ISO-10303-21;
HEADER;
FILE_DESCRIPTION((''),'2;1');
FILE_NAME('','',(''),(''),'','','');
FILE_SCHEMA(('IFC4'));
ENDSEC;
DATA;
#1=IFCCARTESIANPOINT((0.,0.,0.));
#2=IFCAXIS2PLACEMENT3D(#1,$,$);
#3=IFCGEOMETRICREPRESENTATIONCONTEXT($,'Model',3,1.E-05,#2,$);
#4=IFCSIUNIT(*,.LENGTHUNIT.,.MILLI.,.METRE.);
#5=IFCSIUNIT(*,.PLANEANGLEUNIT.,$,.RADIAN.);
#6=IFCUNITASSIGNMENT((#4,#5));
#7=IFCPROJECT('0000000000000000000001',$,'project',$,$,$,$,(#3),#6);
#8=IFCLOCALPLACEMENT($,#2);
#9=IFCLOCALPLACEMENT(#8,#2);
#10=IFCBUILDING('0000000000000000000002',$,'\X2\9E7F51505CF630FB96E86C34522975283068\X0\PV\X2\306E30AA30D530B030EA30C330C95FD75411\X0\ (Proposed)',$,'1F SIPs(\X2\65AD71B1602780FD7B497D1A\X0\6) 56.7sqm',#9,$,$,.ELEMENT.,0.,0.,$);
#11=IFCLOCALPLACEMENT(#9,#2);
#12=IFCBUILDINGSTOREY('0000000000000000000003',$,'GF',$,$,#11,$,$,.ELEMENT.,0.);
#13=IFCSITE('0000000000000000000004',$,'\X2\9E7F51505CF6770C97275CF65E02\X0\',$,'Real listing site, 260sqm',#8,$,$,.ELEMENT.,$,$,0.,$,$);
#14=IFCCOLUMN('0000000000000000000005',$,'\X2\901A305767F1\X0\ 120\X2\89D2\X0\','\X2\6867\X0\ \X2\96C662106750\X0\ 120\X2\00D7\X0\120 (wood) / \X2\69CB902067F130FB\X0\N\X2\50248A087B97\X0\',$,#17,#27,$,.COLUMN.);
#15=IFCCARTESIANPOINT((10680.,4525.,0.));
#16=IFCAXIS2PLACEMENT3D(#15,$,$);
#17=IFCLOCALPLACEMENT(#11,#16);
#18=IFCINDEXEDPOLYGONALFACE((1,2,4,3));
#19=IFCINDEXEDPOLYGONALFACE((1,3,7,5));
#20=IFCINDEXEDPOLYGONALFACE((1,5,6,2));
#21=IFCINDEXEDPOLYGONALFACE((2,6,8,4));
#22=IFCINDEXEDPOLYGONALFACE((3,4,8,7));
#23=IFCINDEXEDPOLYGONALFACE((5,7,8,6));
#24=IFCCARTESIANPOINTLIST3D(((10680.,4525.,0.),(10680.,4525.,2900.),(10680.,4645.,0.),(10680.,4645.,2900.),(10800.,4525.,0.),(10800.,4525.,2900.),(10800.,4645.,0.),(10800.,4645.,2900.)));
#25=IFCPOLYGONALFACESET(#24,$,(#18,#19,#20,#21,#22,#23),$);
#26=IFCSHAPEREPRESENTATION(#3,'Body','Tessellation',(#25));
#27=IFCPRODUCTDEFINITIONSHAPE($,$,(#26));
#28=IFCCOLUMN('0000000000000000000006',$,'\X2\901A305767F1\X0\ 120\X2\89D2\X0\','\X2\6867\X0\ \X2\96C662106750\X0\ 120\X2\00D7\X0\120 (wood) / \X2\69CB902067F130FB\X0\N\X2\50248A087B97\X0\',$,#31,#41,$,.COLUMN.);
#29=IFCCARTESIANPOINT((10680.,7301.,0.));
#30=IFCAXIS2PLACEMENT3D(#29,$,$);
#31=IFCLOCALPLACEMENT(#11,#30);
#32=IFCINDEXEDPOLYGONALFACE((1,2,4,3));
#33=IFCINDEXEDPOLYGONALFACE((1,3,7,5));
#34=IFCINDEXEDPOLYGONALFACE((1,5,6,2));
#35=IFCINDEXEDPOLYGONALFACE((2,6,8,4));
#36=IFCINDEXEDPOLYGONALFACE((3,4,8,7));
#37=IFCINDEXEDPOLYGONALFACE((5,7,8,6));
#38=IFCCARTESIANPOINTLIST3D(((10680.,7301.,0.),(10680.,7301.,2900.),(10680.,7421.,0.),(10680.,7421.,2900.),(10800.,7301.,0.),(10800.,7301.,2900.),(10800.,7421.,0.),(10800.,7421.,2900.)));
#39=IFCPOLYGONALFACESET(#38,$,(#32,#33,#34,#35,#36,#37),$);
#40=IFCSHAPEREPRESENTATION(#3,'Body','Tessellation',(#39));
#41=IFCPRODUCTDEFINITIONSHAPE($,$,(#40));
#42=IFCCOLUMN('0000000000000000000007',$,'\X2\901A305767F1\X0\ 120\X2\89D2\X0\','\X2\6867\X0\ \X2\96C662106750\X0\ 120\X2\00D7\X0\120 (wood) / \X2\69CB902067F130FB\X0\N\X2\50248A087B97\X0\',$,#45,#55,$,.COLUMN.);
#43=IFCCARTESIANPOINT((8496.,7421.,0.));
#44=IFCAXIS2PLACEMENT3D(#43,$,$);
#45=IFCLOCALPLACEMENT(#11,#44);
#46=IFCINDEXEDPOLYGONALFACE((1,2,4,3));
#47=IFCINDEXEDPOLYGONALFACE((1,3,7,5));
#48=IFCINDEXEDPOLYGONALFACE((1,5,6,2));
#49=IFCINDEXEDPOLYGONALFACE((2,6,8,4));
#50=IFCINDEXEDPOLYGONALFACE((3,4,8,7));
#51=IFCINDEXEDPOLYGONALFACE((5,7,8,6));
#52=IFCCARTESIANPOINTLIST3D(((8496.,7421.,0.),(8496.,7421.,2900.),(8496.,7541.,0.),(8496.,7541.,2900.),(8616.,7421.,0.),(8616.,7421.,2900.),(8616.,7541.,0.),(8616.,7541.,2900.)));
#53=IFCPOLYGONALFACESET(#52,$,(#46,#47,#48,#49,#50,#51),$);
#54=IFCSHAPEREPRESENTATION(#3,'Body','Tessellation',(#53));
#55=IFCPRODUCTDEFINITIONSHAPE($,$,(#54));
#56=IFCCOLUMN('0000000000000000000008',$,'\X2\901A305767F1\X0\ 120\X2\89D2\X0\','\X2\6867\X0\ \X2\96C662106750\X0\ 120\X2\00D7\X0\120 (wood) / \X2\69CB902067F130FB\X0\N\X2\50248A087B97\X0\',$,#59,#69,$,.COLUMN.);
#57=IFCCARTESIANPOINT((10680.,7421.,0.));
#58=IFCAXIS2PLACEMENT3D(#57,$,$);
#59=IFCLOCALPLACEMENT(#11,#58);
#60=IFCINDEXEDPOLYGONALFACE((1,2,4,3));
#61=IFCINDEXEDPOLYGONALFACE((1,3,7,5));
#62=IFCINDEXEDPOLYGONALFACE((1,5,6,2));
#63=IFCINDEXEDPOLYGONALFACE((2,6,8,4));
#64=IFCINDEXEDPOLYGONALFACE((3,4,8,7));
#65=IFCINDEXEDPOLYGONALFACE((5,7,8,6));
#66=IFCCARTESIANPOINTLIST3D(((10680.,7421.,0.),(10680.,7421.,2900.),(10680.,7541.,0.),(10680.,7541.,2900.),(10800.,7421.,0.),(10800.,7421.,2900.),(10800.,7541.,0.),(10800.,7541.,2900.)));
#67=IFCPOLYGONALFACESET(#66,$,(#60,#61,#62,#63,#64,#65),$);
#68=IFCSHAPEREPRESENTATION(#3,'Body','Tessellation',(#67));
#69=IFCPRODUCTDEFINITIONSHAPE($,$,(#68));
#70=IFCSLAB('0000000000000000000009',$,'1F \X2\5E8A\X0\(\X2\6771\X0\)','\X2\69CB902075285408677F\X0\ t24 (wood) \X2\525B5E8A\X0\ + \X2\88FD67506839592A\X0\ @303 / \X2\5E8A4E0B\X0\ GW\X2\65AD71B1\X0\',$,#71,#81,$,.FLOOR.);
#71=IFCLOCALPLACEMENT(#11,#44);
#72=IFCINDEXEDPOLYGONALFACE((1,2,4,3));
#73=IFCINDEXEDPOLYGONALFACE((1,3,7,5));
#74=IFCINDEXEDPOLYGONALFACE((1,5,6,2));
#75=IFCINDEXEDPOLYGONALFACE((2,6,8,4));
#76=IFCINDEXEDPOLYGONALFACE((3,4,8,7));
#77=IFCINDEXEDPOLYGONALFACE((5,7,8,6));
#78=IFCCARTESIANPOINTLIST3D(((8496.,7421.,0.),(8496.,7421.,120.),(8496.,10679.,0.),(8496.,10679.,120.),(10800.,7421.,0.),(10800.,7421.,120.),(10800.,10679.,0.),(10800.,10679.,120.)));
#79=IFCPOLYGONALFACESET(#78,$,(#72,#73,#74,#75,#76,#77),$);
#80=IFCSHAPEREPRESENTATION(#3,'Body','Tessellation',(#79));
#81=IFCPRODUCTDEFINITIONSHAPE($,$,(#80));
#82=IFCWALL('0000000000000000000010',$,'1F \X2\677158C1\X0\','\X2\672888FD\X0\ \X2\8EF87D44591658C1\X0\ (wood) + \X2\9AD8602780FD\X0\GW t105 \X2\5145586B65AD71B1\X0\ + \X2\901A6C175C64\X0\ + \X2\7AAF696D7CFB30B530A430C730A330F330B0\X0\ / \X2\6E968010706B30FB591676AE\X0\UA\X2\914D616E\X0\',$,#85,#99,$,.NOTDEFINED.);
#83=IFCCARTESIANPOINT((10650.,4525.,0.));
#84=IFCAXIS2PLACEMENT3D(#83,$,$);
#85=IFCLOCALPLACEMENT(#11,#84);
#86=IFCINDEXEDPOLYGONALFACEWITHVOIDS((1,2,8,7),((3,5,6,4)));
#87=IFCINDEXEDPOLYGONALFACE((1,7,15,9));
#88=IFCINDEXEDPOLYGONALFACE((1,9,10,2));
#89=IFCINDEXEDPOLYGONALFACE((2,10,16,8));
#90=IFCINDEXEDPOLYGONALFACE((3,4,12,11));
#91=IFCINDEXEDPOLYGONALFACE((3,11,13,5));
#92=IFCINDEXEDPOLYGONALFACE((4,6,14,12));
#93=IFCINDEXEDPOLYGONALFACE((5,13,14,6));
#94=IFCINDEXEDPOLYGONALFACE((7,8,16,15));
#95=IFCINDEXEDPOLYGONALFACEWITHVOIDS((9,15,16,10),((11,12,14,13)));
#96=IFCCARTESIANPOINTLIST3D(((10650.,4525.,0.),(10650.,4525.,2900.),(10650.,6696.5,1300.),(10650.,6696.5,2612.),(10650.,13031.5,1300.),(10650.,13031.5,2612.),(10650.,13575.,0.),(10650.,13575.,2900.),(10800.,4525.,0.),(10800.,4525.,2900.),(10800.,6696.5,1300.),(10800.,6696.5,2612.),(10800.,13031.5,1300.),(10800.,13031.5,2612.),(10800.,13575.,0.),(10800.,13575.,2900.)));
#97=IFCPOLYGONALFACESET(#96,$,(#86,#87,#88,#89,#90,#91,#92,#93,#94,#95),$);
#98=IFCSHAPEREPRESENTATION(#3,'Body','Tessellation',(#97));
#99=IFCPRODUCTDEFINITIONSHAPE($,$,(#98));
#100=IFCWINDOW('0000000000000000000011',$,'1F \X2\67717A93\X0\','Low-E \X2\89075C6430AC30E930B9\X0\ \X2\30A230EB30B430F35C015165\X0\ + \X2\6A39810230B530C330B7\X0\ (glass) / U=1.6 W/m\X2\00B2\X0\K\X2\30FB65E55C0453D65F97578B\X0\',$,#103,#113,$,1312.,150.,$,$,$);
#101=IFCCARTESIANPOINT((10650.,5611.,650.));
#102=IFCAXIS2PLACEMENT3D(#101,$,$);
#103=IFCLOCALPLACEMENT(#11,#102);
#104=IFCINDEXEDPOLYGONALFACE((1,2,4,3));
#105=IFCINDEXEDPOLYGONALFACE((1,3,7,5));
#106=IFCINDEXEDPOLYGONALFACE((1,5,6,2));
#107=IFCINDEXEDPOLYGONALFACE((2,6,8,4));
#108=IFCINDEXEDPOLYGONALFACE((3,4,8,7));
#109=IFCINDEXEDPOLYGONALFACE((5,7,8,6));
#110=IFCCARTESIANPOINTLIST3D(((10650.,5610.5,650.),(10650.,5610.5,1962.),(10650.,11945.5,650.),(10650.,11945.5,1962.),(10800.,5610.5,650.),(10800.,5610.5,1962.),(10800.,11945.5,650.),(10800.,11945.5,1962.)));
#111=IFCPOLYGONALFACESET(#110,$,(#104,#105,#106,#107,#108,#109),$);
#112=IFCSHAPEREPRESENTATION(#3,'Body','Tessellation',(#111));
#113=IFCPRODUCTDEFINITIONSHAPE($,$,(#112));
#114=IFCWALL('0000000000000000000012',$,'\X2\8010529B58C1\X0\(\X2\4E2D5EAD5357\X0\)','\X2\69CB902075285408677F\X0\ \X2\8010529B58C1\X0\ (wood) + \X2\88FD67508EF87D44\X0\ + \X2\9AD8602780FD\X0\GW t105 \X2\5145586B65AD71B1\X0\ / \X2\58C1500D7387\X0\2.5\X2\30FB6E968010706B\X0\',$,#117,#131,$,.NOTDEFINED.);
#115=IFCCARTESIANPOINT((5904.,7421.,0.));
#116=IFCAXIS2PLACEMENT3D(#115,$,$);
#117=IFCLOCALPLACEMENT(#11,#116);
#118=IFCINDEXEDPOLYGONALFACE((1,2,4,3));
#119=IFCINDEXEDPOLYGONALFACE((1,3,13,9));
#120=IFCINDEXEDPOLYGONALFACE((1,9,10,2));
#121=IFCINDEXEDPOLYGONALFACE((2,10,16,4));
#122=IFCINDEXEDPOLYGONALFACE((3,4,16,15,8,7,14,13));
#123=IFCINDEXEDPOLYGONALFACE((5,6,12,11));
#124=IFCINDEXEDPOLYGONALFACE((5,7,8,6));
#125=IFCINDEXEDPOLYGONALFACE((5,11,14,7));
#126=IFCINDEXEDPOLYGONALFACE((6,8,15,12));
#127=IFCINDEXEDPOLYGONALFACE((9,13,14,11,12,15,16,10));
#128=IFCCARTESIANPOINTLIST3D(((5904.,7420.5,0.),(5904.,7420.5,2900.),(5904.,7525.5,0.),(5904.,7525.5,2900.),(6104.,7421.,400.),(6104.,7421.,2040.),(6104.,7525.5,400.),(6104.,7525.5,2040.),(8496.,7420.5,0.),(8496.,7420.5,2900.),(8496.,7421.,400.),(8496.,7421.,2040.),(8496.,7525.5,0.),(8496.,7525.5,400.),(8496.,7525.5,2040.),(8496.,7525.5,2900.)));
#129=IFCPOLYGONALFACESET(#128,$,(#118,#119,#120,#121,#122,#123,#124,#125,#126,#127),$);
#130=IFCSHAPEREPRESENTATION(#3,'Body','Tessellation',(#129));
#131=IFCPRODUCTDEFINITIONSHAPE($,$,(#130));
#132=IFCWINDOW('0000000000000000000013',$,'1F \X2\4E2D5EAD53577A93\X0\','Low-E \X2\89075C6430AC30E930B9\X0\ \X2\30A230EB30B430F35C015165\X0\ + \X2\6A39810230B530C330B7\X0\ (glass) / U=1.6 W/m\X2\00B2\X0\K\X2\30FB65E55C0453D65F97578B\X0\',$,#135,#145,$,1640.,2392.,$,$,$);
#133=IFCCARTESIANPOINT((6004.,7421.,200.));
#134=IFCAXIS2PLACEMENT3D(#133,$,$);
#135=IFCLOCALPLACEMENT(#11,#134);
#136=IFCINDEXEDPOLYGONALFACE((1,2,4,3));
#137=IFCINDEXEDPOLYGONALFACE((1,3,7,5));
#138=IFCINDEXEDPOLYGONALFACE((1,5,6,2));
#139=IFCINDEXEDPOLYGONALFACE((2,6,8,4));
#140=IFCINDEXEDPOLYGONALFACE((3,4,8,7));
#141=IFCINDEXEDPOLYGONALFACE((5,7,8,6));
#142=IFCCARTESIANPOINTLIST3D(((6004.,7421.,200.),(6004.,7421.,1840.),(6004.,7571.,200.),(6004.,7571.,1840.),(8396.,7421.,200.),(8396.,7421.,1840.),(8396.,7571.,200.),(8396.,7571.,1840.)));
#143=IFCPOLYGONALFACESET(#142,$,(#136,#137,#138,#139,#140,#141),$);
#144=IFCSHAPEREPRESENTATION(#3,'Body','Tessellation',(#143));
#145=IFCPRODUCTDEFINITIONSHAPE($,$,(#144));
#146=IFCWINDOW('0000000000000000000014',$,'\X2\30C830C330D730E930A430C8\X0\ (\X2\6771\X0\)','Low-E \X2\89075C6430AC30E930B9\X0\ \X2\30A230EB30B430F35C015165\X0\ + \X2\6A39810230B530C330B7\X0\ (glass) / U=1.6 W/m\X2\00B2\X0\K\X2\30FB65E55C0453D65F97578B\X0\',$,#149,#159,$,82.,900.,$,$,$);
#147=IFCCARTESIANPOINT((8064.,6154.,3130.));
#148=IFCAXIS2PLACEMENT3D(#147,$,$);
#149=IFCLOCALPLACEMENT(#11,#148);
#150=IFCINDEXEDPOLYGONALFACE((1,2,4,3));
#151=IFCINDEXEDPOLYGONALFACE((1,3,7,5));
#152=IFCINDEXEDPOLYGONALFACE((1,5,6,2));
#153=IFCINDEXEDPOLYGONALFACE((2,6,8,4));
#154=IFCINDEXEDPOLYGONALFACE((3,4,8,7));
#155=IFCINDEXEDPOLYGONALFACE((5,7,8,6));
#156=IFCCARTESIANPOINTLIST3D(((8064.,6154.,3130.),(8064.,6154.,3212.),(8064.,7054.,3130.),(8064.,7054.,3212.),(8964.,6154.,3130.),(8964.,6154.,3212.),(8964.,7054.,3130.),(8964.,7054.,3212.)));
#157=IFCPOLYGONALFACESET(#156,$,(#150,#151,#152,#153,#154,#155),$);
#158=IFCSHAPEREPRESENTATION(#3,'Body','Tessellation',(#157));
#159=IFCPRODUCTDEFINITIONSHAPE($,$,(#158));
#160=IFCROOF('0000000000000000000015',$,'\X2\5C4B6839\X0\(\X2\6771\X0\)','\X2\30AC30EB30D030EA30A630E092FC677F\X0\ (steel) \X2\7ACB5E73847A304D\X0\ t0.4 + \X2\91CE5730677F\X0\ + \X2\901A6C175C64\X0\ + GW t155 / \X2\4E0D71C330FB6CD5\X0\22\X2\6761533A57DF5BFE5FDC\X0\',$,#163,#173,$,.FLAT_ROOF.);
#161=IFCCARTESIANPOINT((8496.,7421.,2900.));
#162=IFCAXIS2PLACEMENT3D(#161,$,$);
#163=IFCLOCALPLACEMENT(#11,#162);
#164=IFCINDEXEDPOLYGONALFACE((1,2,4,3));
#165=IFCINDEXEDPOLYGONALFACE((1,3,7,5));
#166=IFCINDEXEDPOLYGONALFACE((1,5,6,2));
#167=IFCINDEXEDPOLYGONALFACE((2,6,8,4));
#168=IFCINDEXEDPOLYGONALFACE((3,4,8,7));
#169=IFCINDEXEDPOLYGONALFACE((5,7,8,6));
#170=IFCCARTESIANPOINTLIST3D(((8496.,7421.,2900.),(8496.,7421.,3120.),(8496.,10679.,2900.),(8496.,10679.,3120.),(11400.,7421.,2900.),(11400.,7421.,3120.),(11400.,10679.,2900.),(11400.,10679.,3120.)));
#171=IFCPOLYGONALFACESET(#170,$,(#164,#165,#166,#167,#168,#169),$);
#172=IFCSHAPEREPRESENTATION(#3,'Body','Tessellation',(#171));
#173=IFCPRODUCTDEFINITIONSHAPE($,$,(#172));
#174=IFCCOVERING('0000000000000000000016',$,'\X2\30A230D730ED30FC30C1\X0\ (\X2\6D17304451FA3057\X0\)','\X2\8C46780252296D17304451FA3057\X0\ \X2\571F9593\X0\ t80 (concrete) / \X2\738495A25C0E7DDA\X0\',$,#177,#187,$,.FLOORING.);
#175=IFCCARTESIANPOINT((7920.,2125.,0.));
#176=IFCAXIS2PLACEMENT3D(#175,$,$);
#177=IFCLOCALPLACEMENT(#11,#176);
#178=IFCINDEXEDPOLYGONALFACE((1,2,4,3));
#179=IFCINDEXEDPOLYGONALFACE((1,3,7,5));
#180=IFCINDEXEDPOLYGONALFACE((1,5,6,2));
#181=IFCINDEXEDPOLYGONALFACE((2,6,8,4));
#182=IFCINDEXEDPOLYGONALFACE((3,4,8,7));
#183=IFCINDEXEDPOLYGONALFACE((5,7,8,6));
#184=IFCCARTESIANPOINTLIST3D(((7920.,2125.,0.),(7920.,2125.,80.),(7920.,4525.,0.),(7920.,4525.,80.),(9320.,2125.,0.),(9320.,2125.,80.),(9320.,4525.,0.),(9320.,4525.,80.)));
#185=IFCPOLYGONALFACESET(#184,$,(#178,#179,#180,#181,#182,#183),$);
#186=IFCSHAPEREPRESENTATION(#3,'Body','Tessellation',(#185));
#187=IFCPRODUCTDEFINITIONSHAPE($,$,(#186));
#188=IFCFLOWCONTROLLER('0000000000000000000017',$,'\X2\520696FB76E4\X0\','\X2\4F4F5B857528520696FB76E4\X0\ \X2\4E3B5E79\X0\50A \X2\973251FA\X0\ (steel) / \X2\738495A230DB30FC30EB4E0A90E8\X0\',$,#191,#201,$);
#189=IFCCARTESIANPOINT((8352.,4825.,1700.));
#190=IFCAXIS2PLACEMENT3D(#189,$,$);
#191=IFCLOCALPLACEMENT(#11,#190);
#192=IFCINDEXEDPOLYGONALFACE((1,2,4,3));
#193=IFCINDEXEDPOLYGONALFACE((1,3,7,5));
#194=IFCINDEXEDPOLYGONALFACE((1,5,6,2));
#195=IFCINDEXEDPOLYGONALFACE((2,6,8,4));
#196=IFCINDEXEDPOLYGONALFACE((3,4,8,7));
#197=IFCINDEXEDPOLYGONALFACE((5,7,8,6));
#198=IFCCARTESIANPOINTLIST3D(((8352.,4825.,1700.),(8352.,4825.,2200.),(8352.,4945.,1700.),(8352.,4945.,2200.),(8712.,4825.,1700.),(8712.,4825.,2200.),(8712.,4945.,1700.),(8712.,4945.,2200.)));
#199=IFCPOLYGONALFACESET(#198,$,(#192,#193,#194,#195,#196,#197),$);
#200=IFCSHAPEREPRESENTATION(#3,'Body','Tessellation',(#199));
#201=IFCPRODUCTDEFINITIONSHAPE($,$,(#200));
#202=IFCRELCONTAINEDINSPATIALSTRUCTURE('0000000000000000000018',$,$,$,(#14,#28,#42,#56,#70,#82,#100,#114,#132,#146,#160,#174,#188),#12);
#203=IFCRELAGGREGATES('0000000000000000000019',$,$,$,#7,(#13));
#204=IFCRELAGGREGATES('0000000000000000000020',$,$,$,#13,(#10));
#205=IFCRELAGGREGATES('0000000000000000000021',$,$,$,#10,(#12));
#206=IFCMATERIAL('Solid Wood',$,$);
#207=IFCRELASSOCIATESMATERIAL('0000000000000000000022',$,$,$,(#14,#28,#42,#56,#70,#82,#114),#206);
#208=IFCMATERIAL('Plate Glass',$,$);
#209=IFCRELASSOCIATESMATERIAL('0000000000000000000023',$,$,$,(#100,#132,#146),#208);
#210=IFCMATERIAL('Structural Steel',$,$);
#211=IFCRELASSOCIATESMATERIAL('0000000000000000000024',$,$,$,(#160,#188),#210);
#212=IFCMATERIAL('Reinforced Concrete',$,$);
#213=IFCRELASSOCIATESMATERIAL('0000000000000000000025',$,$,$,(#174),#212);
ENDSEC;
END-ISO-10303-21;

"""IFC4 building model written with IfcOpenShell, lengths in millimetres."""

from ifc_helpers import new_model, si_unit, frame, frame_2d, origin, place, context, project, spatial, rectangle, extrude, material, element, fill, save


model = new_model("IFC4")

# Units and contexts
model_context = context("Model", 3, precision=1e-05, world=origin())
ifc_project = project(units=[si_unit("LENGTHUNIT", "METRE", prefix="MILLI"), si_unit("PLANEANGLEUNIT", "RADIAN")], contexts=[model_context])

# Site, building, storey
site_placement = place(None, origin())
site = spatial("IfcSite", under=ifc_project, at=site_placement, Name="鹿児島県霧島市", ObjectType="Real listing site, 260sqm", CompositionType="ELEMENT", RefElevation=0.0)
building_placement = place(site_placement, origin())
building = spatial("IfcBuilding", under=site, at=building_placement, Name="鹿児島・雨水利用とPVのオフグリッド志向 (Proposed)", ObjectType="1F SIPs(断熱性能等級6) 56.7sqm", CompositionType="ELEMENT", ElevationOfRefHeight=0.0, ElevationOfTerrain=0.0)
storey_placement = place(building_placement, origin())
storey = spatial("IfcBuildingStorey", under=building, at=storey_placement, Name="GF", CompositionType="ELEMENT", Elevation=0.0)

# Columns
ifc_material_1 = material(Name="Solid Wood")
column_1_placement = place(storey_placement, frame((10680.0, 4525.0, 0.0)))
element("IfcColumn", 1, at=column_1_placement, inside=storey, material=ifc_material_1, Name="通し柱 120角", Description="桧 集成材 120×120 (wood) / 構造柱・N値計算", PredefinedType="COLUMN", context=model_context, shape_type="SweptSolid", body=[
    extrude(rectangle(XDim=120.0, YDim=120.0, at=frame_2d((60.0, 60.0))), frame((10680.0, 4525.0, 0.0)), (0.0, 0.0, 1.0), 2900.0),
])
column_2_placement = place(storey_placement, frame((10680.0, 7301.0, 0.0)))
element("IfcColumn", 2, at=column_2_placement, inside=storey, material=ifc_material_1, Name="通し柱 120角", Description="桧 集成材 120×120 (wood) / 構造柱・N値計算", PredefinedType="COLUMN", context=model_context, shape_type="SweptSolid", body=[
    extrude(rectangle(XDim=120.0, YDim=120.0, at=frame_2d((60.0, 60.0))), frame((10680.0, 7301.0, 0.0)), (0.0, 0.0, 1.0), 2900.0),
])
column_3_placement = place(storey_placement, frame((8496.0, 7421.0, 0.0)))
element("IfcColumn", 3, at=column_3_placement, inside=storey, material=ifc_material_1, Name="通し柱 120角", Description="桧 集成材 120×120 (wood) / 構造柱・N値計算", PredefinedType="COLUMN", context=model_context, shape_type="SweptSolid", body=[
    extrude(rectangle(XDim=120.0, YDim=120.0, at=frame_2d((60.0, 60.0))), frame((8496.0, 7421.0, 0.0)), (0.0, 0.0, 1.0), 2900.0),
])
column_4_placement = place(storey_placement, frame((10680.0, 7421.0, 0.0)))
element("IfcColumn", 4, at=column_4_placement, inside=storey, material=ifc_material_1, Name="通し柱 120角", Description="桧 集成材 120×120 (wood) / 構造柱・N値計算", PredefinedType="COLUMN", context=model_context, shape_type="SweptSolid", body=[
    extrude(rectangle(XDim=120.0, YDim=120.0, at=frame_2d((60.0, 60.0))), frame((10680.0, 7421.0, 0.0)), (0.0, 0.0, 1.0), 2900.0),
])

# Slab
slab_placement = place(storey_placement, frame((8496.0, 7421.0, 0.0)))
element("IfcSlab", 5, at=slab_placement, inside=storey, material=ifc_material_1, Name="1F 床(東)", Description="構造用合板 t24 (wood) 剛床 + 製材根太 @303 / 床下 GW断熱", PredefinedType="FLOOR", context=model_context, shape_type="SweptSolid", body=[
    extrude(rectangle(XDim=2304.0, YDim=3258.0, at=frame_2d((1152.0, 1629.0))), frame((8496.0, 7421.0, 0.0)), (0.0, 0.0, 1.0), 120.0),
])

# Walls, openings, windows
wall_1_placement = place(storey_placement, frame((10650.0, 4525.0, 0.0)))
wall_1 = element("IfcWall", 6, at=wall_1_placement, inside=storey, material=ifc_material_1, Name="1F 東壁", Description="木製 軸組外壁 (wood) + 高性能GW t105 充填断熱 + 通気層 + 窯業系サイディング / 準耐火・外皮UA配慮", PredefinedType="NOTDEFINED", context=model_context, shape_type="SweptSolid", body=[
    extrude(rectangle(XDim=150.0, YDim=9050.0, at=frame_2d((75.0, 4525.0))), frame((10650.0, 4525.0, 0.0)), (0.0, 0.0, 1.0), 2900.0),
])
opening_1_placement = place(storey_placement, frame((10650.0, 5611.0, 650.0)))
opening_1 = element("IfcOpeningElement", 7, at=opening_1_placement, cuts=wall_1, PredefinedType="NOTDEFINED", context=model_context, shape_type="SweptSolid", body=[
    extrude(rectangle(XDim=150.0, YDim=6335.0, at=frame_2d((75.0, 3167.0))), frame((10650.0, 5611.0, 650.0)), (0.0, 0.0, 1.0), 1312.0),
])
ifc_material_2 = material(Name="Plate Glass")
window_1_placement = place(storey_placement, frame((10650.0, 5611.0, 650.0)))
window_1 = element("IfcWindow", 8, at=window_1_placement, inside=storey, material=ifc_material_2, Name="1F 東窓", Description="Low-E 複層ガラス アルゴン封入 + 樹脂サッシ (glass) / U=1.6 W/m²K・日射取得型", OverallHeight=1312.0, OverallWidth=150.0, context=model_context, shape_type="SweptSolid", body=[
    extrude(rectangle(XDim=150.0, YDim=6335.0, at=frame_2d((75.0, 3167.0))), frame((10650.0, 5611.0, 650.0)), (0.0, 0.0, 1.0), 1312.0),
])
fill(opening_1, window_1)
wall_2_placement = place(storey_placement, frame((5904.0, 7421.0, 0.0)))
wall_2 = element("IfcWall", 9, at=wall_2_placement, inside=storey, material=ifc_material_1, Name="耐力壁(中庭南)", Description="構造用合板 耐力壁 (wood) + 製材軸組 + 高性能GW t105 充填断熱 / 壁倍率2.5・準耐火", PredefinedType="NOTDEFINED", context=model_context, shape_type="SweptSolid", body=[
    extrude(rectangle(XDim=2592.0, YDim=105.0, at=frame_2d((1296.0, 52.0))), frame((5904.0, 7421.0, 0.0)), (0.0, 0.0, 1.0), 2900.0),
])
opening_2_placement = place(storey_placement, frame((6004.0, 7421.0, 200.0)))
opening_2 = element("IfcOpeningElement", 10, at=opening_2_placement, cuts=wall_2, PredefinedType="NOTDEFINED", context=model_context, shape_type="SweptSolid", body=[
    extrude(rectangle(XDim=2392.0, YDim=150.0, at=frame_2d((1196.0, 75.0))), frame((6004.0, 7421.0, 200.0)), (0.0, 0.0, 1.0), 1640.0),
])
window_2_placement = place(storey_placement, frame((6004.0, 7421.0, 200.0)))
window_2 = element("IfcWindow", 11, at=window_2_placement, inside=storey, material=ifc_material_2, Name="1F 中庭南窓", Description="Low-E 複層ガラス アルゴン封入 + 樹脂サッシ (glass) / U=1.6 W/m²K・日射取得型", OverallHeight=1640.0, OverallWidth=2392.0, context=model_context, shape_type="SweptSolid", body=[
    extrude(rectangle(XDim=2392.0, YDim=150.0, at=frame_2d((1196.0, 75.0))), frame((6004.0, 7421.0, 200.0)), (0.0, 0.0, 1.0), 1640.0),
])
fill(opening_2, window_2)

# Window
window_3_placement = place(storey_placement, frame((8064.0, 6154.0, 3130.0)))
element("IfcWindow", 12, at=window_3_placement, inside=storey, material=ifc_material_2, Name="トップライト (東)", Description="Low-E 複層ガラス アルゴン封入 + 樹脂サッシ (glass) / U=1.6 W/m²K・日射取得型", OverallHeight=82.0, OverallWidth=900.0, context=model_context, shape_type="SweptSolid", body=[
    extrude(rectangle(XDim=900.0, YDim=900.0, at=frame_2d((450.0, 450.0))), frame((8064.0, 6154.0, 3130.0)), (0.0, 0.0, 1.0), 82.0),
])

# Roof
ifc_material_3 = material(Name="Structural Steel")
roof_placement = place(storey_placement, frame((8496.0, 7421.0, 2900.0)))
element("IfcRoof", 13, at=roof_placement, inside=storey, material=ifc_material_3, Name="屋根(東)", Description="ガルバリウム鋼板 (steel) 立平葺き t0.4 + 野地板 + 通気層 + GW t155 / 不燃・法22条区域対応", PredefinedType="FLAT_ROOF", context=model_context, shape_type="SweptSolid", body=[
    extrude(rectangle(XDim=2904.0, YDim=3258.0, at=frame_2d((1452.0, 1629.0))), frame((8496.0, 7421.0, 2900.0)), (0.0, 0.0, 1.0), 220.0),
])

# Covering
ifc_material_4 = material(Name="Reinforced Concrete")
covering_placement = place(storey_placement, frame((7920.0, 2125.0, 0.0)))
element("IfcCovering", 14, at=covering_placement, inside=storey, material=ifc_material_4, Name="アプローチ (洗い出し)", Description="豆砂利洗い出し 土間 t80 (concrete) / 玄関導線", PredefinedType="FLOORING", context=model_context, shape_type="SweptSolid", body=[
    extrude(rectangle(XDim=1400.0, YDim=2400.0, at=frame_2d((700.0, 1200.0))), frame((7920.0, 2125.0, 0.0)), (0.0, 0.0, 1.0), 80.0),
])

# Flow controller
flow_controller_placement = place(storey_placement, frame((8352.0, 4825.0, 1700.0)))
element("IfcFlowController", 15, at=flow_controller_placement, inside=storey, material=ifc_material_3, Name="分電盤", Description="住宅用分電盤 主幹50A 露出 (steel) / 玄関ホール上部", context=model_context, shape_type="SweptSolid", body=[
    extrude(rectangle(XDim=360.0, YDim=120.0, at=frame_2d((180.0, 60.0))), frame((8352.0, 4825.0, 1700.0)), (0.0, 0.0, 1.0), 500.0),
])

save(model, "model.ifc")
